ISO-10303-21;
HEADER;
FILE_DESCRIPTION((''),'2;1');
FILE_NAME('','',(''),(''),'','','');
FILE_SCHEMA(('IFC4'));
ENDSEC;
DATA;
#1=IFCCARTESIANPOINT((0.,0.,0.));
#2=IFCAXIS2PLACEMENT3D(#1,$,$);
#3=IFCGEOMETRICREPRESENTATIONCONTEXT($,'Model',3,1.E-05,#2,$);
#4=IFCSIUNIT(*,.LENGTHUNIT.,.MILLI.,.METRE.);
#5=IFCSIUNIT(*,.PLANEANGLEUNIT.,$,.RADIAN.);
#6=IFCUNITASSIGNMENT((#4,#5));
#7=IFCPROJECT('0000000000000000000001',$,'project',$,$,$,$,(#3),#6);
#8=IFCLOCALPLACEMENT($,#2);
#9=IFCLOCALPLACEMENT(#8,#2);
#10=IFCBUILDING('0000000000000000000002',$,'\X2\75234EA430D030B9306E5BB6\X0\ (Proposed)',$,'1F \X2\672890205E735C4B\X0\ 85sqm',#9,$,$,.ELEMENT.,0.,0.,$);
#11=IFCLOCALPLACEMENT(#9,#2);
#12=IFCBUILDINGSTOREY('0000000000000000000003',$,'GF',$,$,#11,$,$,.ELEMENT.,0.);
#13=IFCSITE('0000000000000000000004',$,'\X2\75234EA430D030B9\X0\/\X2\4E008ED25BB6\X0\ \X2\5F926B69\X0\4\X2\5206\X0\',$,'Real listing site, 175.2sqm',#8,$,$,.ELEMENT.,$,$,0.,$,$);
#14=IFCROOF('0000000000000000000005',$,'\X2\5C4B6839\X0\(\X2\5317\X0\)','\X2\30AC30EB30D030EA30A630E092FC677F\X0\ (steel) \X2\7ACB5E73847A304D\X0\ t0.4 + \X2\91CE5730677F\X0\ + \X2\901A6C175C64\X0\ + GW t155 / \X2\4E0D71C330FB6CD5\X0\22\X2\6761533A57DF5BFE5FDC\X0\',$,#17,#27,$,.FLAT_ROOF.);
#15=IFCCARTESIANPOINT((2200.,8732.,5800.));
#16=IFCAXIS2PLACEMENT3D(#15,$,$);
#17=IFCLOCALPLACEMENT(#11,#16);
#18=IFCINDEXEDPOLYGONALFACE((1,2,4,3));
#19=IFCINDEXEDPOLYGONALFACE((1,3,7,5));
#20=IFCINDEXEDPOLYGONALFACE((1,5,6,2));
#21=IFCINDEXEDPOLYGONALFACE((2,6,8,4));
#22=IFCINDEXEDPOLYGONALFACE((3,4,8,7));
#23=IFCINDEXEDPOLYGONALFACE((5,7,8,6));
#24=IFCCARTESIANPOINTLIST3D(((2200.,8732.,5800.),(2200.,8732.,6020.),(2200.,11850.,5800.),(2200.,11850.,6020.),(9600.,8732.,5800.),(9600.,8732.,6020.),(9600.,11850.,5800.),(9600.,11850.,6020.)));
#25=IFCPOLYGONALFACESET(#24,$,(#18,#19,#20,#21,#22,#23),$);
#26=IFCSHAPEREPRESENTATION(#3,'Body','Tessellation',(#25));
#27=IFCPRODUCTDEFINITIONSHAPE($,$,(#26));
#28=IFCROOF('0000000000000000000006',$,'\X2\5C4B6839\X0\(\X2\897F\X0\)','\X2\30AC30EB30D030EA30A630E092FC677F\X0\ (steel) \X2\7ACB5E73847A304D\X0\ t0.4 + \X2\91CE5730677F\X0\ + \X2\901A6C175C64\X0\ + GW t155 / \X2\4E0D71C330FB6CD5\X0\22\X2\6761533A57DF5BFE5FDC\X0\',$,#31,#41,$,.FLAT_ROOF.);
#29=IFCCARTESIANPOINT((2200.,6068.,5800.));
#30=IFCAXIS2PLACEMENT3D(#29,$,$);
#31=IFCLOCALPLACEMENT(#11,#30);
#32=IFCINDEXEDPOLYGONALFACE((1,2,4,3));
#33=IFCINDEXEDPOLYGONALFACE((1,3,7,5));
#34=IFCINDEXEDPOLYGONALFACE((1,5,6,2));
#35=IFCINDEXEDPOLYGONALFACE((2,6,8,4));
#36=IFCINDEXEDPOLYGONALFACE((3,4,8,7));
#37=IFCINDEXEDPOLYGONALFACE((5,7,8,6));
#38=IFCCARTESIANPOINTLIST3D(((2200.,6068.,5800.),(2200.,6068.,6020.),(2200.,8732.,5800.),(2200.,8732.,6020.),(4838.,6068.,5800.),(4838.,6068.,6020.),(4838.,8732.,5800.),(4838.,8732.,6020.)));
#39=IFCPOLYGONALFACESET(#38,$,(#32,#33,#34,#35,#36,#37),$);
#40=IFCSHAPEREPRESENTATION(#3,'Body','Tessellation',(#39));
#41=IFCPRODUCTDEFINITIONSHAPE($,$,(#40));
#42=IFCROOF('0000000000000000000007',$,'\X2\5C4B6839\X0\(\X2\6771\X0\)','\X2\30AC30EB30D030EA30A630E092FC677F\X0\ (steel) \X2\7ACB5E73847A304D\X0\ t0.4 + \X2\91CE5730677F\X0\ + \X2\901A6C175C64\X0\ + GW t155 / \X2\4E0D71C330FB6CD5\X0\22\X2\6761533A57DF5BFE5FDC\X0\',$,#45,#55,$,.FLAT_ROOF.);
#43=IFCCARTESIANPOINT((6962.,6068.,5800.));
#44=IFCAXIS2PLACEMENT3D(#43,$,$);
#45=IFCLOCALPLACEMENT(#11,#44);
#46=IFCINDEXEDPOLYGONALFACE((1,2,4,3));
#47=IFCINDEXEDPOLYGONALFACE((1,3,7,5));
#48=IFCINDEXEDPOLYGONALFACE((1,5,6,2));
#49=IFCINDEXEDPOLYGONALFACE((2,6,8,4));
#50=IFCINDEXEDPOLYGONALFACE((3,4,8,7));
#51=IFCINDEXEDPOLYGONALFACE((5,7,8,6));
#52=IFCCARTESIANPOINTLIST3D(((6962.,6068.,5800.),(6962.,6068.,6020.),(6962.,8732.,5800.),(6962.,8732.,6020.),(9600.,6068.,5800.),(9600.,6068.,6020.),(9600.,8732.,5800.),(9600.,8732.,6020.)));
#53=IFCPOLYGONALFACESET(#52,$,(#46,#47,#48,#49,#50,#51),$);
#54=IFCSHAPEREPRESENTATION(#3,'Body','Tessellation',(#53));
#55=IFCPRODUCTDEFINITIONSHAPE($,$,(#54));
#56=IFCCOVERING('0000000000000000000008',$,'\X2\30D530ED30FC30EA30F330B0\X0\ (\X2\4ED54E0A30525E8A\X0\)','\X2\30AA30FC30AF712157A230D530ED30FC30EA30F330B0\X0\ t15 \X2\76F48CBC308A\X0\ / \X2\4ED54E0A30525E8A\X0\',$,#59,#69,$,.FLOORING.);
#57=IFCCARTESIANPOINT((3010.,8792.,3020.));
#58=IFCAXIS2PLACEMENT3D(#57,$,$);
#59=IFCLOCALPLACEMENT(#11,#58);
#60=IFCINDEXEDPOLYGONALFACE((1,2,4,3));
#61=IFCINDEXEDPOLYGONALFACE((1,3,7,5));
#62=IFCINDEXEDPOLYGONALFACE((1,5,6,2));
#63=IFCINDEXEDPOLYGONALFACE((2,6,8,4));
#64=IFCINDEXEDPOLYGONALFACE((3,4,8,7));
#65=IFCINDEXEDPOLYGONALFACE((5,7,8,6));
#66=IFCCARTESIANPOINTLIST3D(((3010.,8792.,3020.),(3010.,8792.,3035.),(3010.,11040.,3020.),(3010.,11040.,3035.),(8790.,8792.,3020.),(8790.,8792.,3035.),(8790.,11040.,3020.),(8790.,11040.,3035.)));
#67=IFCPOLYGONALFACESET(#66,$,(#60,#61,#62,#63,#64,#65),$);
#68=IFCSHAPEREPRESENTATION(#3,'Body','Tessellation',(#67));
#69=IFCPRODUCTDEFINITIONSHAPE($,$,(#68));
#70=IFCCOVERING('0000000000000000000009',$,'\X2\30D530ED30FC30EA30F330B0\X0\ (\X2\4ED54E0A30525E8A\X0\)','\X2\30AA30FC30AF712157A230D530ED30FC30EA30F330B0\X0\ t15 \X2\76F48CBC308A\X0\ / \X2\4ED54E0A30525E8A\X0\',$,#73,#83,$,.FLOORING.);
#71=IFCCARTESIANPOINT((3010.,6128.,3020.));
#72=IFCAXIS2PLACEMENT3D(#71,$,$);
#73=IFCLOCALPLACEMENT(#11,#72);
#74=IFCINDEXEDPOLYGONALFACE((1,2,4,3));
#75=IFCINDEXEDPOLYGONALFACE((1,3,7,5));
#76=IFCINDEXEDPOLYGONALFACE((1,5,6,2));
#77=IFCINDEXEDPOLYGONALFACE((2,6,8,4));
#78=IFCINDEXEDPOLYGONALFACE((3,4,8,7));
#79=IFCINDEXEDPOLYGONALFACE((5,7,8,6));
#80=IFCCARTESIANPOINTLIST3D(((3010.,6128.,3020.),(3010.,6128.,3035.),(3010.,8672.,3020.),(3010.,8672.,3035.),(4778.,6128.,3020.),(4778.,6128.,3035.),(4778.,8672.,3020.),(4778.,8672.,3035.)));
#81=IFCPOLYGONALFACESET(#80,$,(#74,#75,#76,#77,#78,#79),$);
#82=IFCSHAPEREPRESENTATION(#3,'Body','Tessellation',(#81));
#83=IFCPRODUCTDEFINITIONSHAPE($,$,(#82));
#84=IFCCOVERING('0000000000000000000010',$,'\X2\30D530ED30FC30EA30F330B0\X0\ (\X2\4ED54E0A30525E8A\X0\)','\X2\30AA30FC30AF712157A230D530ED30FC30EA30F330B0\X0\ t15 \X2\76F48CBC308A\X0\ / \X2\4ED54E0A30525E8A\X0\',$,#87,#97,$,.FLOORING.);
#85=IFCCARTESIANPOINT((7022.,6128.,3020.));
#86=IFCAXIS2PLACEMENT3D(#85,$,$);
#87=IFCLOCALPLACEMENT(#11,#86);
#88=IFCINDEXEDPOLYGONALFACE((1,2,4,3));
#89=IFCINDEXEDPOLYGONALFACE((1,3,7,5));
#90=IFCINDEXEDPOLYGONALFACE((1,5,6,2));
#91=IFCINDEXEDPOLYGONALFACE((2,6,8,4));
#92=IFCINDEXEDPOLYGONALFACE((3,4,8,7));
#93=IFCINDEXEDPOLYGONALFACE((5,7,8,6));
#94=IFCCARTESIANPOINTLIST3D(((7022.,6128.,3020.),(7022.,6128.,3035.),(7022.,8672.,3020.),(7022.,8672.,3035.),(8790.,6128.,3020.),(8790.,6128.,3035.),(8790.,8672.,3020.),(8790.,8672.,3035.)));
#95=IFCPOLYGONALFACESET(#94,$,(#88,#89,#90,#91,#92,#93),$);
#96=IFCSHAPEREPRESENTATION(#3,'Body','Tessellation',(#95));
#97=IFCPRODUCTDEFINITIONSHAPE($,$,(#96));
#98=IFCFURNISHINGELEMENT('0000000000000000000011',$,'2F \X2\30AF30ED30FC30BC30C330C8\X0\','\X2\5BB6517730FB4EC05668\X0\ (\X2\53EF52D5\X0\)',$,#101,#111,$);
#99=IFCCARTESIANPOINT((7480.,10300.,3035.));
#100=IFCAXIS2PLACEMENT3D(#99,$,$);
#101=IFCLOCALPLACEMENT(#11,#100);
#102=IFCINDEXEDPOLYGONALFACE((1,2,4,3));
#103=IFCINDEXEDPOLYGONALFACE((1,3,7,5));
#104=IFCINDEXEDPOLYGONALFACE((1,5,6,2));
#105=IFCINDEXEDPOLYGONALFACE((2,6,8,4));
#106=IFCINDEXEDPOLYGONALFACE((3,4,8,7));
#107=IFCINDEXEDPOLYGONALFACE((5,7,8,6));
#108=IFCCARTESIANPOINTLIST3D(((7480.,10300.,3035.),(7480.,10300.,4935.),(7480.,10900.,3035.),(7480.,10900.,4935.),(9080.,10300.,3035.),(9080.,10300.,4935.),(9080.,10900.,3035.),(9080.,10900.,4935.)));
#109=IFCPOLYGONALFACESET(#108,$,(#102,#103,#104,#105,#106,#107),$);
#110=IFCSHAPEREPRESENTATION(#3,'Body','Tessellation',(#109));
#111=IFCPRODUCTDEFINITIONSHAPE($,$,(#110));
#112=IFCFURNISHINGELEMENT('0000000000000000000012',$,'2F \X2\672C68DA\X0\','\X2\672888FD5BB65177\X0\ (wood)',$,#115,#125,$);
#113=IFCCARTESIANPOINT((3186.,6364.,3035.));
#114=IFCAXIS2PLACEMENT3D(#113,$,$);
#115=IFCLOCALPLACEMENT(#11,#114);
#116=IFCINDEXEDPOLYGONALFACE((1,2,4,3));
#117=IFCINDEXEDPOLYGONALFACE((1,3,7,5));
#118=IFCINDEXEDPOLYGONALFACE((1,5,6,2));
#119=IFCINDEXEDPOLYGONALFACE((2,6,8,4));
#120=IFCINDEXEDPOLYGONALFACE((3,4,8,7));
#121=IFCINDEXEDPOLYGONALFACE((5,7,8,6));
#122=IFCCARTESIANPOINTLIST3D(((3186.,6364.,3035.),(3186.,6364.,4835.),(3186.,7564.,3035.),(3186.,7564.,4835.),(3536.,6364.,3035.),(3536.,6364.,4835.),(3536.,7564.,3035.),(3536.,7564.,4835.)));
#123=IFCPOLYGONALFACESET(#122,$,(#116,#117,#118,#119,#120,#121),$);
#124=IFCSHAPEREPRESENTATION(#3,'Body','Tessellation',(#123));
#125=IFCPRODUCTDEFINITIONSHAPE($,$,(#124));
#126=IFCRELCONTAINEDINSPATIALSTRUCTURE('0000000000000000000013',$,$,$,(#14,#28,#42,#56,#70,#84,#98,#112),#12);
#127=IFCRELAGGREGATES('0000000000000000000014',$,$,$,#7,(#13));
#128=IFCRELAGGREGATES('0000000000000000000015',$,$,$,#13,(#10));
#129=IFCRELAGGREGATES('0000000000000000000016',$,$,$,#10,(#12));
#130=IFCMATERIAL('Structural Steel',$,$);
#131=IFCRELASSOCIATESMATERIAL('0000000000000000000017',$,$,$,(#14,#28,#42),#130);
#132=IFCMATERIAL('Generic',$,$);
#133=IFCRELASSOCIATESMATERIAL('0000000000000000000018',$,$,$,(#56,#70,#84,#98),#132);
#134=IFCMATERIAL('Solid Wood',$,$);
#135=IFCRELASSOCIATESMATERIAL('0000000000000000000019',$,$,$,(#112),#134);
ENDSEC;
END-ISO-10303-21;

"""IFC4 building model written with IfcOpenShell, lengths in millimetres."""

from ifc_helpers import new_model, si_unit, frame, frame_2d, origin, place, context, project, spatial, rectangle, extrude, material, element, save


model = new_model("IFC4")

# Units and contexts
model_context = context("Model", 3, precision=1e-05, world=origin())
ifc_project = project(units=[si_unit("LENGTHUNIT", "METRE", prefix="MILLI"), si_unit("PLANEANGLEUNIT", "RADIAN")], contexts=[model_context])

# Site, building, storey
site_placement = place(None, origin())
site = spatial("IfcSite", under=ifc_project, at=site_placement, Name="産交バス/一軒家 徒歩4分", ObjectType="Real listing site, 175.2sqm", CompositionType="ELEMENT", RefElevation=0.0)
building_placement = place(site_placement, origin())
building = spatial("IfcBuilding", under=site, at=building_placement, Name="産交バスの家 (Proposed)", ObjectType="1F 木造平屋 85sqm", CompositionType="ELEMENT", ElevationOfRefHeight=0.0, ElevationOfTerrain=0.0)
storey_placement = place(building_placement, origin())
storey = spatial("IfcBuildingStorey", under=building, at=storey_placement, Name="GF", CompositionType="ELEMENT", Elevation=0.0)

# Shared definitions
ifc_material_1 = material(Name="Solid Wood")

# Shared definitions
ifc_material_2 = material(Name="Generic")

# Roofs
ifc_material_3 = material(Name="Structural Steel")
for number, where, name in (
    (1, (2200.0, 8732.0, 5800.0), "屋根(北)"),
):
    element("IfcRoof", number, at=place(storey_placement, frame(where)), inside=storey, material=ifc_material_3, Name=name, Description="ガルバリウム鋼板 (steel) 立平葺き t0.4 + 野地板 + 通気層 + GW t155 / 不燃・法22条区域対応", PredefinedType="FLAT_ROOF", context=model_context, shape_type="SweptSolid", body=[
        extrude(rectangle(XDim=7400.0, YDim=3118.0, at=frame_2d((3700.0, 1559.0))), frame((2200.0, 8732.0, 5800.0)), (0.0, 0.0, 1.0), 220.0),
    ])
roof_1_placement = place(storey_placement, frame((2200.0, 6068.0, 5800.0)))
element("IfcRoof", 2, at=roof_1_placement, inside=storey, material=ifc_material_3, Name="屋根(西)", Description="ガルバリウム鋼板 (steel) 立平葺き t0.4 + 野地板 + 通気層 + GW t155 / 不燃・法22条区域対応", PredefinedType="FLAT_ROOF", context=model_context, shape_type="SweptSolid", body=[
    extrude(rectangle(XDim=2638.0, YDim=2664.0, at=frame_2d((1319.0, 1332.0))), frame((2200.0, 6068.0, 5800.0)), (0.0, 0.0, 1.0), 220.0),
])
roof_2_placement = place(storey_placement, frame((6962.0, 6068.0, 5800.0)))
element("IfcRoof", 3, at=roof_2_placement, inside=storey, material=ifc_material_3, Name="屋根(東)", Description="ガルバリウム鋼板 (steel) 立平葺き t0.4 + 野地板 + 通気層 + GW t155 / 不燃・法22条区域対応", PredefinedType="FLAT_ROOF", context=model_context, shape_type="SweptSolid", body=[
    extrude(rectangle(XDim=2638.0, YDim=2664.0, at=frame_2d((1319.0, 1332.0))), frame((6962.0, 6068.0, 5800.0)), (0.0, 0.0, 1.0), 220.0),
])

# Coverings
covering_1_placement = place(storey_placement, frame((3010.0, 8792.0, 3020.0)))
element("IfcCovering", 4, at=covering_1_placement, inside=storey, material=ifc_material_2, Name="フローリング (仕上げ床)", Description="オーク無垢フローリング t15 直貼り / 仕上げ床", PredefinedType="FLOORING", context=model_context, shape_type="SweptSolid", body=[
    extrude(rectangle(XDim=5780.0, YDim=2248.0, at=frame_2d((2890.0, 1124.0))), frame((3010.0, 8792.0, 3020.0)), (0.0, 0.0, 1.0), 15.0),
])
covering_2_placement = place(storey_placement, frame((3010.0, 6128.0, 3020.0)))
element("IfcCovering", 5, at=covering_2_placement, inside=storey, material=ifc_material_2, Name="フローリング (仕上げ床)", Description="オーク無垢フローリング t15 直貼り / 仕上げ床", PredefinedType="FLOORING", context=model_context, shape_type="SweptSolid", body=[
    extrude(rectangle(XDim=1768.0, YDim=2544.0, at=frame_2d((884.0, 1272.0))), frame((3010.0, 6128.0, 3020.0)), (0.0, 0.0, 1.0), 15.0),
])
covering_3_placement = place(storey_placement, frame((7022.0, 6128.0, 3020.0)))
element("IfcCovering", 6, at=covering_3_placement, inside=storey, material=ifc_material_2, Name="フローリング (仕上げ床)", Description="オーク無垢フローリング t15 直貼り / 仕上げ床", PredefinedType="FLOORING", context=model_context, shape_type="SweptSolid", body=[
    extrude(rectangle(XDim=1768.0, YDim=2544.0, at=frame_2d((884.0, 1272.0))), frame((7022.0, 6128.0, 3020.0)), (0.0, 0.0, 1.0), 15.0),
])

# Furnishing elements
furnishing_1_placement = place(storey_placement, frame((7480.0, 10300.0, 3035.0)))
element("IfcFurnishingElement", 7, at=furnishing_1_placement, inside=storey, material=ifc_material_2, Name="2F クローゼット", Description="家具・什器 (可動)", context=model_context, shape_type="SweptSolid", body=[
    extrude(rectangle(XDim=1600.0, YDim=600.0, at=frame_2d((800.0, 300.0))), frame((7480.0, 10300.0, 3035.0)), (0.0, 0.0, 1.0), 1900.0),
])
furnishing_2_placement = place(storey_placement, frame((3186.0, 6364.0, 3035.0)))
element("IfcFurnishingElement", 8, at=furnishing_2_placement, inside=storey, material=ifc_material_1, Name="2F 本棚", Description="木製家具 (wood)", context=model_context, shape_type="SweptSolid", body=[
    extrude(rectangle(XDim=350.0, YDim=1200.0, at=frame_2d((175.0, 600.0))), frame((3186.0, 6364.0, 3035.0)), (0.0, 0.0, 1.0), 1800.0),
])

save(model, "model.ifc")
